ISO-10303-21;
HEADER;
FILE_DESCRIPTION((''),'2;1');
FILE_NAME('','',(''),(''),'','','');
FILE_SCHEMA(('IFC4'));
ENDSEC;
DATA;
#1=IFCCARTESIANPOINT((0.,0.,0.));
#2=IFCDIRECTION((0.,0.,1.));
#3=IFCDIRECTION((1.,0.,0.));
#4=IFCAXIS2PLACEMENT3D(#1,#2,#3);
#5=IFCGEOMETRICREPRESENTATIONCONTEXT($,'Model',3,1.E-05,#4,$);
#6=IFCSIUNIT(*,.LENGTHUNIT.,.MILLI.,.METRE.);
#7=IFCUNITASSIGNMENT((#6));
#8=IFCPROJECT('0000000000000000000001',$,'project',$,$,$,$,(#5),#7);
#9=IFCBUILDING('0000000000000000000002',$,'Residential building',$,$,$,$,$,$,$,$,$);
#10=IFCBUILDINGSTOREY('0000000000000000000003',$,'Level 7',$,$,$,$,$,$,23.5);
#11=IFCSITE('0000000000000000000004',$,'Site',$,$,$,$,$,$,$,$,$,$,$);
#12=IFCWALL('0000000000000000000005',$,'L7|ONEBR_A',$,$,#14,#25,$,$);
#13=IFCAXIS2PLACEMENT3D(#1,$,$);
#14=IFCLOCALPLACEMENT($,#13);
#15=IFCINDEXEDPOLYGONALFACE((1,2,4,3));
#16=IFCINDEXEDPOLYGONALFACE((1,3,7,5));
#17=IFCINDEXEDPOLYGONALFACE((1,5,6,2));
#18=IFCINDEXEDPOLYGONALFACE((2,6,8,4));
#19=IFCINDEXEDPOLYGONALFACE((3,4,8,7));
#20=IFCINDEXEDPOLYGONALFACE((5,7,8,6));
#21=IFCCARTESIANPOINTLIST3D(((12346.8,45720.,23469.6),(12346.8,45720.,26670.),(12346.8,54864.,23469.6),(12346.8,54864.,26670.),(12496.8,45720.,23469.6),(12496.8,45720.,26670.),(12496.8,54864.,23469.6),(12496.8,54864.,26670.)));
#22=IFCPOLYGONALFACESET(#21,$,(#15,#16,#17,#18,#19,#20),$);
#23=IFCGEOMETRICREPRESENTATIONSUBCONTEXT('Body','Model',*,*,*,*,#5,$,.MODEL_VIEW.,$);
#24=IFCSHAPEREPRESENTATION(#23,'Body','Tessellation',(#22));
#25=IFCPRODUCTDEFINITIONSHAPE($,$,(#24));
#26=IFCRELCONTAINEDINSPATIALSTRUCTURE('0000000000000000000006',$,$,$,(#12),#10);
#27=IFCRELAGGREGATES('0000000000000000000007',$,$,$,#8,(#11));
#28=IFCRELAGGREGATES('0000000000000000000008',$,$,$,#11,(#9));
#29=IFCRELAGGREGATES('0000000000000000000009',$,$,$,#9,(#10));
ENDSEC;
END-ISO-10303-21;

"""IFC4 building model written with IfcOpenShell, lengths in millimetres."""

from ifc_helpers import new_model, si_unit, frame, origin_with_axes, place, context, subcontext, project, spatial, indexed_curve, outline, extrude, element, save


model = new_model("IFC4")

# Units and contexts
model_context = context("Model", 3, precision=1e-05, world=origin_with_axes())
body_context = subcontext(model_context, "Body", "Model", "MODEL_VIEW")
ifc_project = project(units=[si_unit("LENGTHUNIT", "METRE", prefix="MILLI")], contexts=[model_context])

# Site, building, storey
site = spatial("IfcSite", under=ifc_project, Name="Site")
building = spatial("IfcBuilding", under=site, Name="Residential building")
storey = spatial("IfcBuildingStorey", under=building, Name="Level 7", Elevation=23.5)

# Wall
for number, where, z_axis, x_axis, name in (
    (1, (12496.8, 45720.0, 23469.6), (0.0, 0.0, 1.0), (0.0, 1.0, 0.0), "L7|ONEBR_A"),
):
    element("IfcWall", number, at=place(None, frame(where, z_axis=z_axis, x_axis=x_axis)), inside=storey, Name=name, context=body_context, shape_type="SweptSolid", body=[
        extrude(outline(indexed_curve([(0.0, 0.0), (0.0, 150.0), (9144.0, 150.0), (9144.0, 0.0), (0.0, 0.0)], self_intersect=False)), origin_with_axes(), (0.0, 0.0, 1.0), 3200.4),
    ])

save(model, "model.ifc")
